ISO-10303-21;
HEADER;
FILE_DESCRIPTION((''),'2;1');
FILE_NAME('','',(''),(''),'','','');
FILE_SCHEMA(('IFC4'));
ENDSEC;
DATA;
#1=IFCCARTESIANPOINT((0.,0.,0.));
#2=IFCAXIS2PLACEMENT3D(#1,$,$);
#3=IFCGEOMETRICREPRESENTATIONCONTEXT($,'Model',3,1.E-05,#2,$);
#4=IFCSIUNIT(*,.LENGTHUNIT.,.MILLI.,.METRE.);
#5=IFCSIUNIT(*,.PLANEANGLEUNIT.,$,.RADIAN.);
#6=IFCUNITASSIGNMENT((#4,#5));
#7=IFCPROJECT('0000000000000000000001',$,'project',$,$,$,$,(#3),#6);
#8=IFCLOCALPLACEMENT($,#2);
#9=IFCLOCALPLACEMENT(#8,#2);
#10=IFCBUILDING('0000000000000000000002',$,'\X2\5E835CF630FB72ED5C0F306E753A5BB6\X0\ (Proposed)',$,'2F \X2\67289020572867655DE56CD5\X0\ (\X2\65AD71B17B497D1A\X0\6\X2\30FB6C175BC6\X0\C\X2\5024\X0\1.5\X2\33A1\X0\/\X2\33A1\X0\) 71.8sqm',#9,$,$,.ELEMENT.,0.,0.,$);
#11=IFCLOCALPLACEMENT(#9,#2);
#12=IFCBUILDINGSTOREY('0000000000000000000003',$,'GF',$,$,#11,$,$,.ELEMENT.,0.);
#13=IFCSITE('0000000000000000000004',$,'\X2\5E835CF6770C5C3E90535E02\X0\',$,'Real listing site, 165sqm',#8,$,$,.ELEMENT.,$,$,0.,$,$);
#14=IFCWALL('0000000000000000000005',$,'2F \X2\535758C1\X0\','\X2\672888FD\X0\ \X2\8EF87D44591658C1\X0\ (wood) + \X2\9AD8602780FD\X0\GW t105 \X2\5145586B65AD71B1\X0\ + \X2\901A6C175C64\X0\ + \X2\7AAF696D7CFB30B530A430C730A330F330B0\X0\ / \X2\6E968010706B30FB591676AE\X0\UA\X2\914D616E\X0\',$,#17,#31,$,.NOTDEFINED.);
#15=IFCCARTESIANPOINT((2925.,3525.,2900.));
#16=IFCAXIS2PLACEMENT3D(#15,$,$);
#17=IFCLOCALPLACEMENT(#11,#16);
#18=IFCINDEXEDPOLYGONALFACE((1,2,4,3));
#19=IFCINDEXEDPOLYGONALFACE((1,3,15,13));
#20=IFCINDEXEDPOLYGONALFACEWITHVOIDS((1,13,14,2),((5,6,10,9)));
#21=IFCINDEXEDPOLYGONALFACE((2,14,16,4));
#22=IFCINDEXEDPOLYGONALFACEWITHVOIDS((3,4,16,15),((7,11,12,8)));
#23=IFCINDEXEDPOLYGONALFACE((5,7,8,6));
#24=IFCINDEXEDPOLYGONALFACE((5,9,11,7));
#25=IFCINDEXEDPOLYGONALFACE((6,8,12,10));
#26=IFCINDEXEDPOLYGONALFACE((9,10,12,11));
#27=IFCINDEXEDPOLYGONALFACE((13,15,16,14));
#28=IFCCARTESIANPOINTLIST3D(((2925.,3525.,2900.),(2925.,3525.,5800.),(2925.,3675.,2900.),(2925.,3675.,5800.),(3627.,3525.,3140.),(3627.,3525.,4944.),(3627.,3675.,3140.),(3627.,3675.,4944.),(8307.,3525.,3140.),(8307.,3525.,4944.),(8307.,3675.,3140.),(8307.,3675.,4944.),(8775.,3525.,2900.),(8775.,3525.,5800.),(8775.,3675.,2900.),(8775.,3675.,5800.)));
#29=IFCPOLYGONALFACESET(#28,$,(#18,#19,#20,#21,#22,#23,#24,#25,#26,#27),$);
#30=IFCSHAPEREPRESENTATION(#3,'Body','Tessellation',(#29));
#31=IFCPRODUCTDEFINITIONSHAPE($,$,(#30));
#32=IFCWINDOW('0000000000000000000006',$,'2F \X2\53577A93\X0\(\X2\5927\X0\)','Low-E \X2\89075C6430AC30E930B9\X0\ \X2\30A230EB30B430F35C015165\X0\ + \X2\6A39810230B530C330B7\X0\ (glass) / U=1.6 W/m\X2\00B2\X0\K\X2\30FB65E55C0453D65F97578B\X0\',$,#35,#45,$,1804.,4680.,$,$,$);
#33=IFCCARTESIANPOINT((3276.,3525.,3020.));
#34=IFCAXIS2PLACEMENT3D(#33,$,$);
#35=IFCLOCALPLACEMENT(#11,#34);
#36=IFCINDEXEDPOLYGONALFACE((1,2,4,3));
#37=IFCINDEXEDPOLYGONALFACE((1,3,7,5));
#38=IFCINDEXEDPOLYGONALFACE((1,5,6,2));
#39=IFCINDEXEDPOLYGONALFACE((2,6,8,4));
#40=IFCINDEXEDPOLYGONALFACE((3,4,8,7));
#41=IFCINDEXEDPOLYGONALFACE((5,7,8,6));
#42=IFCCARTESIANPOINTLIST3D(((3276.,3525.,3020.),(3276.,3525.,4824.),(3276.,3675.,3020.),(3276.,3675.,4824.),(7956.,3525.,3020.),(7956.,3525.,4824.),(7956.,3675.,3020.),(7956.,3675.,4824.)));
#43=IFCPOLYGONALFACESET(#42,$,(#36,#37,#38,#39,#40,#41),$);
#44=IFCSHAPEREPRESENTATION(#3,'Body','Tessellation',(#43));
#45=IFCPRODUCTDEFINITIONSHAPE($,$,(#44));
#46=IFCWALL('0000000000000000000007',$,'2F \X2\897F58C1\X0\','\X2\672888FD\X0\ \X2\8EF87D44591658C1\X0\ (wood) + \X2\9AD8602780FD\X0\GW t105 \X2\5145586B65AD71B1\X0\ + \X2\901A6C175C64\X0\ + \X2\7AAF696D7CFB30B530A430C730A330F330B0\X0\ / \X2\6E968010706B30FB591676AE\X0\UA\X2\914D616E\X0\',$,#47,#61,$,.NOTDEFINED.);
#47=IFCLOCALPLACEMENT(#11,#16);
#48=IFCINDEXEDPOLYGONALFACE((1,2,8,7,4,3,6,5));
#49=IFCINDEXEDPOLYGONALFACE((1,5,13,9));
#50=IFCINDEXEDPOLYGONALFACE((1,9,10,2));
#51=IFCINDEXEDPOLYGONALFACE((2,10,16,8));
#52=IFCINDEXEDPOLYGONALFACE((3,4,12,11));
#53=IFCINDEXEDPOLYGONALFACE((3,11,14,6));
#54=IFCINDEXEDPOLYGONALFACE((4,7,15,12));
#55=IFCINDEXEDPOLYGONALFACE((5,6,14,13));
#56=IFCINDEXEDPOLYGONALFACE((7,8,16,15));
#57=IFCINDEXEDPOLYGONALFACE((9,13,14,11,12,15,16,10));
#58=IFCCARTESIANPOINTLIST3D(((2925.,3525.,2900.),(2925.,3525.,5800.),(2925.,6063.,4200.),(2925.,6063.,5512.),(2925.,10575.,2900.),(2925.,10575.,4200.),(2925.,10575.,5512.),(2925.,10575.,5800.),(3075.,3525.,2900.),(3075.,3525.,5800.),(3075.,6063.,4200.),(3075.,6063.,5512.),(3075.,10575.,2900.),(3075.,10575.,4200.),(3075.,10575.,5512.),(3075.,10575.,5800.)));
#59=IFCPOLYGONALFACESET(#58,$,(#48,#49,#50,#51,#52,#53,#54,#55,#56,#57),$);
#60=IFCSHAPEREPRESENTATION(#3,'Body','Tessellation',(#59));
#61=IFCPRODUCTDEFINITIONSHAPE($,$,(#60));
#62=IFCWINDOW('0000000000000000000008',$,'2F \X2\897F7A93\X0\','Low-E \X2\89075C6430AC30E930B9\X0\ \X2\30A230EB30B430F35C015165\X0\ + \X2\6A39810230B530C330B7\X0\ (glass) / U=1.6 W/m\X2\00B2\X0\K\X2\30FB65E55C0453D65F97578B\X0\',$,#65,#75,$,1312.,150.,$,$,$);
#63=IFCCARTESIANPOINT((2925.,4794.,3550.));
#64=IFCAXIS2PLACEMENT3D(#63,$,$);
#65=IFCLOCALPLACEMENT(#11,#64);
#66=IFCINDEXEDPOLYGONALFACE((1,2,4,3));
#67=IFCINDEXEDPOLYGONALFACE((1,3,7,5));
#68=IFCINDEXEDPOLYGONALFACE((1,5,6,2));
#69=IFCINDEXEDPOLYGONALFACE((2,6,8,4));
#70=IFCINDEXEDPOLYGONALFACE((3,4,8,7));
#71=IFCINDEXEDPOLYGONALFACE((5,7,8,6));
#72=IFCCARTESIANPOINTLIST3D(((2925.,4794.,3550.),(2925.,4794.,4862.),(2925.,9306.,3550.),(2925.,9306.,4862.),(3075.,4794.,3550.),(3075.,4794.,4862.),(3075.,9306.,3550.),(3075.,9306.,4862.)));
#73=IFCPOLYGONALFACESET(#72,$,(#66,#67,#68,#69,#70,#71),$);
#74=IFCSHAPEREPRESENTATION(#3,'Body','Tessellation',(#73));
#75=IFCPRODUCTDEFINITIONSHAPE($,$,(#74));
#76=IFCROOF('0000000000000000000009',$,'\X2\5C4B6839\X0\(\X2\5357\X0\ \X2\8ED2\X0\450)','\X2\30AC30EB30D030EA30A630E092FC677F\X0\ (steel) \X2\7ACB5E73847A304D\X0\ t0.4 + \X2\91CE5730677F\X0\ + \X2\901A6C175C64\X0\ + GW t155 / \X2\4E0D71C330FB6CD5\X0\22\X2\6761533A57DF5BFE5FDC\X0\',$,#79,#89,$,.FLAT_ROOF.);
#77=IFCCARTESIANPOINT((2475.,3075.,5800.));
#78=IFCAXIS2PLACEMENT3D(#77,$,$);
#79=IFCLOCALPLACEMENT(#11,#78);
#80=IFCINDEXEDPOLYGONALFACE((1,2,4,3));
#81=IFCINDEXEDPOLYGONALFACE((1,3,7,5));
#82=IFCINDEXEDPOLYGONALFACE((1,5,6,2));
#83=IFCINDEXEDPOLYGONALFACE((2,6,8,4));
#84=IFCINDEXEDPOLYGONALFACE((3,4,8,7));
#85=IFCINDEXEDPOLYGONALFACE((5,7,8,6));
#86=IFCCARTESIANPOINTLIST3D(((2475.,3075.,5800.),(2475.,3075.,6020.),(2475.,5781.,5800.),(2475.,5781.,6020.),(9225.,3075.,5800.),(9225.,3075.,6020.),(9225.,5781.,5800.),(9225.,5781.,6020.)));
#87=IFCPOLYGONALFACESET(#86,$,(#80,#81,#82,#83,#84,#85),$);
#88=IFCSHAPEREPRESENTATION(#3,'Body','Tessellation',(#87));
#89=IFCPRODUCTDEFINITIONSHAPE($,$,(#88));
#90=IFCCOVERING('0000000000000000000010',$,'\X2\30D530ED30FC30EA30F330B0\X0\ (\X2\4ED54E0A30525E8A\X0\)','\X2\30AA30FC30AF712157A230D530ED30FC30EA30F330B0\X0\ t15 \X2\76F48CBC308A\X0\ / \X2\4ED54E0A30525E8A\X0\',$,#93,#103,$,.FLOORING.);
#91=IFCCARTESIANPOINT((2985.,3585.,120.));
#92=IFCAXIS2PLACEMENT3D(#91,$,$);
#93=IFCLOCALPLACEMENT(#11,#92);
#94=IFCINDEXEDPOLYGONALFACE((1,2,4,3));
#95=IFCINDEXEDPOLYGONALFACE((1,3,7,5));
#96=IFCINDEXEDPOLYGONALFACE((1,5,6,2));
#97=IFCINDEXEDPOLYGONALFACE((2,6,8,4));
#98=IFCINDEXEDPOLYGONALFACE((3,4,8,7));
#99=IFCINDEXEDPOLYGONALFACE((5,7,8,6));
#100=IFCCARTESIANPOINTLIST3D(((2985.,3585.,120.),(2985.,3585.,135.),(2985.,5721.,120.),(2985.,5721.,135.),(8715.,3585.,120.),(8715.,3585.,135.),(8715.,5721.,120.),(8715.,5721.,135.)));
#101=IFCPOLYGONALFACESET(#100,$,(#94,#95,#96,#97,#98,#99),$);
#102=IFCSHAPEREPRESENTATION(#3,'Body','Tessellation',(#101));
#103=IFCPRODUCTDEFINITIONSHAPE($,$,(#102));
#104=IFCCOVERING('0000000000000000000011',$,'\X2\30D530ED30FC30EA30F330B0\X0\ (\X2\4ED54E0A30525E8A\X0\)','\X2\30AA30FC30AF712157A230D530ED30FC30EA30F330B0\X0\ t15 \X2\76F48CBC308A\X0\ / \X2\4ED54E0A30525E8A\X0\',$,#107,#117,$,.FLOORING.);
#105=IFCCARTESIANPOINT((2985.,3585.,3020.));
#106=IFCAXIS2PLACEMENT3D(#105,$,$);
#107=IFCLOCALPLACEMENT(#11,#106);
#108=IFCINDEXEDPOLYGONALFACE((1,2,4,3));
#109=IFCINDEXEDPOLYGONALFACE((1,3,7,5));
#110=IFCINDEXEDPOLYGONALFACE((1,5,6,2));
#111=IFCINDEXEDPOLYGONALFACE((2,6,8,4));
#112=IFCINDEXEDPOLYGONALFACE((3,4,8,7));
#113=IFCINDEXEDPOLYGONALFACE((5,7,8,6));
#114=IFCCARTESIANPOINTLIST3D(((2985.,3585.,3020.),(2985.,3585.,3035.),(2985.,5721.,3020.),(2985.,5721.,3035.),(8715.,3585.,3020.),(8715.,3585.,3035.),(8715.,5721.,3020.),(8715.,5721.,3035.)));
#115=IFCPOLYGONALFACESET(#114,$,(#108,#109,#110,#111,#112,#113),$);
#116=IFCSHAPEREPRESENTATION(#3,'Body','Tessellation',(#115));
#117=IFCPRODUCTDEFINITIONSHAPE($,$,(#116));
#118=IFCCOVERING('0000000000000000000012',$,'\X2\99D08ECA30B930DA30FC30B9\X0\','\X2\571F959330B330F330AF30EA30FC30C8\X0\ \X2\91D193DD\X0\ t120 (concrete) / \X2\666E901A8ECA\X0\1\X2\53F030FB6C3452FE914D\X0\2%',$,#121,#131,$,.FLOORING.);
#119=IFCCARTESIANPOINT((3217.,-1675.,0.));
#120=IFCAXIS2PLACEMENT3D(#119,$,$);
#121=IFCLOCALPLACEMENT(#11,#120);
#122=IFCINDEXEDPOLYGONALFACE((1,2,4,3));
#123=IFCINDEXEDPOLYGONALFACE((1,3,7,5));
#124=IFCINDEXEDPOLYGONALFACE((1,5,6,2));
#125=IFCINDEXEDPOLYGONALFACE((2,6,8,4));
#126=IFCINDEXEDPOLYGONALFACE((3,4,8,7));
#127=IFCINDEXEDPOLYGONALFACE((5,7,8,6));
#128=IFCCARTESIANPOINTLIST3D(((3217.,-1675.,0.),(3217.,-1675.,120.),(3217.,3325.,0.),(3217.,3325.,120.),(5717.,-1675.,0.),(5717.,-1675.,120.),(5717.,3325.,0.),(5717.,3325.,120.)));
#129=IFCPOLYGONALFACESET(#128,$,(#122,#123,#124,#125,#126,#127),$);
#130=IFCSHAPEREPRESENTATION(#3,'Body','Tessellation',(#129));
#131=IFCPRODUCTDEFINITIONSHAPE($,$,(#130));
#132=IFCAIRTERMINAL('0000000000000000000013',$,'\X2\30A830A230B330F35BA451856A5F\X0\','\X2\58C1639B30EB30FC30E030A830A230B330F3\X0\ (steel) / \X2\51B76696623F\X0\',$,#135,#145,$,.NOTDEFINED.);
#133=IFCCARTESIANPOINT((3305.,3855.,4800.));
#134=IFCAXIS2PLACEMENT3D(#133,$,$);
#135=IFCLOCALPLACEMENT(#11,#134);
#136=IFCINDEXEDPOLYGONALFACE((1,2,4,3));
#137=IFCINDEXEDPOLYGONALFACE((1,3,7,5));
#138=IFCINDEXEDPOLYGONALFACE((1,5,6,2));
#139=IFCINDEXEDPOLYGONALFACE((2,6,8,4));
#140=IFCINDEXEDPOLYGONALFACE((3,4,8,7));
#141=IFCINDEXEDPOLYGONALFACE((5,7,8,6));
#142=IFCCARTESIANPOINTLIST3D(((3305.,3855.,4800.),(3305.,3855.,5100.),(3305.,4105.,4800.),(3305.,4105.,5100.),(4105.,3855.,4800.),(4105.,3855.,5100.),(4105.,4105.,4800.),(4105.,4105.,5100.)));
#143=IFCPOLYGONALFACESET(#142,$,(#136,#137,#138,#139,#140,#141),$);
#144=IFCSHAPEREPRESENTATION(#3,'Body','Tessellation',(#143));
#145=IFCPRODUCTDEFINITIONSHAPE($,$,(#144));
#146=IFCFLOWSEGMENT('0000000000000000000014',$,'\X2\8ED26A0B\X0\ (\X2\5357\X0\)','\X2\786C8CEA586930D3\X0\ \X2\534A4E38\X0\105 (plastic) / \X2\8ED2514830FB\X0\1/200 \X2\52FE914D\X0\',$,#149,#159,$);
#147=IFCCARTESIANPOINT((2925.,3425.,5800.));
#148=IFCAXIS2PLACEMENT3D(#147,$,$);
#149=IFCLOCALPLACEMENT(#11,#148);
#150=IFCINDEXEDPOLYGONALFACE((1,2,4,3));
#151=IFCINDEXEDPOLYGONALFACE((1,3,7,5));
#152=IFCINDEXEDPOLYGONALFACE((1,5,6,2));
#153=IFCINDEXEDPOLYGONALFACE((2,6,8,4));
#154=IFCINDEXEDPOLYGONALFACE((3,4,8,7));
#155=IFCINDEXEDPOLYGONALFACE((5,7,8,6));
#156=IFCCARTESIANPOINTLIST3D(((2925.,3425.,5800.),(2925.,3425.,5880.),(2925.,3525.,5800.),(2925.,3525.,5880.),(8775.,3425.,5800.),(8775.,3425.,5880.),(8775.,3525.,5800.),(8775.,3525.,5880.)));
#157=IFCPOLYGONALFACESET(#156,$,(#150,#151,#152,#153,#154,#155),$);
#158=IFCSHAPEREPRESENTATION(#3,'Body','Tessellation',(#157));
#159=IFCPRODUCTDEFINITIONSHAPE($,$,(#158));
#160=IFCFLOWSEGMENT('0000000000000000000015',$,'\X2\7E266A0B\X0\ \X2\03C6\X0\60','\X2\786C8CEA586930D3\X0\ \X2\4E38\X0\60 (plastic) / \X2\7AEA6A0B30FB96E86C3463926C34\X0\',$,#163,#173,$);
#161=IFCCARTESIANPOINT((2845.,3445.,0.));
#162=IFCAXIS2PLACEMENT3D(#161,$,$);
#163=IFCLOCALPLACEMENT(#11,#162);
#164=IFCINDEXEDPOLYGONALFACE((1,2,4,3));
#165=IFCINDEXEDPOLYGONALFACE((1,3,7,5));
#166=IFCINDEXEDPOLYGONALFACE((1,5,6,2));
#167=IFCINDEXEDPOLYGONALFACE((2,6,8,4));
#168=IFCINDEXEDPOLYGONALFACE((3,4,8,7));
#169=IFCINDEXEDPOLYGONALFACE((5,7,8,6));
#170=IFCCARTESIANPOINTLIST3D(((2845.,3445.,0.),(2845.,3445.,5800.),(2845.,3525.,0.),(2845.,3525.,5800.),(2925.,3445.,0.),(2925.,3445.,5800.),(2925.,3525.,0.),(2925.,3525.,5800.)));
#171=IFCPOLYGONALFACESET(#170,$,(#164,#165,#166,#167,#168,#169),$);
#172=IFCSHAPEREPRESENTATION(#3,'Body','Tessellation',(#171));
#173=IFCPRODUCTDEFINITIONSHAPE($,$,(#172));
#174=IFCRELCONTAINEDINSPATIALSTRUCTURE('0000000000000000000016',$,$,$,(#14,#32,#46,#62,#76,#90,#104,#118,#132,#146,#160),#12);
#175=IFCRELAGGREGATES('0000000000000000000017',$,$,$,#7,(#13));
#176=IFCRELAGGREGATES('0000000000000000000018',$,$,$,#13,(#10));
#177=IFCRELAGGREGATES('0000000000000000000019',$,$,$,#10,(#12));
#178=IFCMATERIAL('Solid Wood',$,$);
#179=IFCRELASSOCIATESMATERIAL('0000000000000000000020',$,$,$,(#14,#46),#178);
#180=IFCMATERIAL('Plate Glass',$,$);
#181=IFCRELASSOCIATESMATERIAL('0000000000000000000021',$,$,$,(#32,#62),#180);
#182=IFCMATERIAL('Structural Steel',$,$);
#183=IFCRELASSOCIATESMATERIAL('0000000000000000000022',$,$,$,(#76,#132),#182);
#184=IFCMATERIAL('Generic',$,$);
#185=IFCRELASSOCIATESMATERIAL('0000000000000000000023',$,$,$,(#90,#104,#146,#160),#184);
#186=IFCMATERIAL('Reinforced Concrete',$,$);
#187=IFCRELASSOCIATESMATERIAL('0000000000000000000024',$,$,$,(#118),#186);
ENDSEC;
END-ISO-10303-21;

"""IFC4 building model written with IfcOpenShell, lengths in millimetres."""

from ifc_helpers import new_model, si_unit, frame, frame_2d, origin, place, context, project, spatial, rectangle, extrude, material, element, fill, save


model = new_model("IFC4")

# Units and contexts
model_context = context("Model", 3, precision=1e-05, world=origin())
ifc_project = project(units=[si_unit("LENGTHUNIT", "METRE", prefix="MILLI"), si_unit("PLANEANGLEUNIT", "RADIAN")], contexts=[model_context])

# Site, building, storey
site_placement = place(None, origin())
site = spatial("IfcSite", under=ifc_project, at=site_placement, Name="広島県尾道市", ObjectType="Real listing site, 165sqm", CompositionType="ELEMENT", RefElevation=0.0)
building_placement = place(site_placement, origin())
building = spatial("IfcBuilding", under=site, at=building_placement, Name="広島・狭小の町家 (Proposed)", ObjectType="2F 木造在来工法 (断熱等級6・気密C値1.5㎡/㎡) 71.8sqm", CompositionType="ELEMENT", ElevationOfRefHeight=0.0, ElevationOfTerrain=0.0)
storey_placement = place(building_placement, origin())
storey = spatial("IfcBuildingStorey", under=building, at=storey_placement, Name="GF", CompositionType="ELEMENT", Elevation=0.0)

# Shared definitions
ifc_material_1 = material(Name="Solid Wood")

# Shared definitions
ifc_material_2 = material(Name="Reinforced Concrete")

# Shared definitions
ifc_material_3 = material(Name="Plate Glass")

# Walls, openings, windows
wall_1_placement = place(storey_placement, frame((2925.0, 3525.0, 2900.0)))
wall_1 = element("IfcWall", 1, at=wall_1_placement, inside=storey, material=ifc_material_1, Name="2F 南壁", Description="木製 軸組外壁 (wood) + 高性能GW t105 充填断熱 + 通気層 + 窯業系サイディング / 準耐火・外皮UA配慮", PredefinedType="NOTDEFINED", context=model_context, shape_type="SweptSolid", body=[
    extrude(rectangle(XDim=5850.0, YDim=150.0, at=frame_2d((2925.0, 75.0))), frame((2925.0, 3525.0, 2900.0)), (0.0, 0.0, 1.0), 2900.0),
])
opening_1_placement = place(storey_placement, frame((3276.0, 3525.0, 3020.0)))
opening_1 = element("IfcOpeningElement", 2, at=opening_1_placement, cuts=wall_1, PredefinedType="NOTDEFINED", context=model_context, shape_type="SweptSolid", body=[
    extrude(rectangle(XDim=4680.0, YDim=150.0, at=frame_2d((2340.0, 75.0))), frame((3276.0, 3525.0, 3020.0)), (0.0, 0.0, 1.0), 1804.0),
])
window_1_placement = place(storey_placement, frame((3276.0, 3525.0, 3020.0)))
window_1 = element("IfcWindow", 3, at=window_1_placement, inside=storey, material=ifc_material_3, Name="2F 南窓(大)", Description="Low-E 複層ガラス アルゴン封入 + 樹脂サッシ (glass) / U=1.6 W/m²K・日射取得型", OverallHeight=1804.0, OverallWidth=4680.0, context=model_context, shape_type="SweptSolid", body=[
    extrude(rectangle(XDim=4680.0, YDim=150.0, at=frame_2d((2340.0, 75.0))), frame((3276.0, 3525.0, 3020.0)), (0.0, 0.0, 1.0), 1804.0),
])
fill(opening_1, window_1)
wall_2_placement = place(storey_placement, frame((2925.0, 3525.0, 2900.0)))
wall_2 = element("IfcWall", 4, at=wall_2_placement, inside=storey, material=ifc_material_1, Name="2F 西壁", Description="木製 軸組外壁 (wood) + 高性能GW t105 充填断熱 + 通気層 + 窯業系サイディング / 準耐火・外皮UA配慮", PredefinedType="NOTDEFINED", context=model_context, shape_type="SweptSolid", body=[
    extrude(rectangle(XDim=150.0, YDim=7050.0, at=frame_2d((75.0, 3525.0))), frame((2925.0, 3525.0, 2900.0)), (0.0, 0.0, 1.0), 2900.0),
])
opening_2_placement = place(storey_placement, frame((2925.0, 4794.0, 3550.0)))
opening_2 = element("IfcOpeningElement", 5, at=opening_2_placement, cuts=wall_2, PredefinedType="NOTDEFINED", context=model_context, shape_type="SweptSolid", body=[
    extrude(rectangle(XDim=150.0, YDim=4512.0, at=frame_2d((75.0, 2256.0))), frame((2925.0, 4794.0, 3550.0)), (0.0, 0.0, 1.0), 1312.0),
])
window_2_placement = place(storey_placement, frame((2925.0, 4794.0, 3550.0)))
window_2 = element("IfcWindow", 6, at=window_2_placement, inside=storey, material=ifc_material_3, Name="2F 西窓", Description="Low-E 複層ガラス アルゴン封入 + 樹脂サッシ (glass) / U=1.6 W/m²K・日射取得型", OverallHeight=1312.0, OverallWidth=150.0, context=model_context, shape_type="SweptSolid", body=[
    extrude(rectangle(XDim=150.0, YDim=4512.0, at=frame_2d((75.0, 2256.0))), frame((2925.0, 4794.0, 3550.0)), (0.0, 0.0, 1.0), 1312.0),
])
fill(opening_2, window_2)

# Roof
ifc_material_4 = material(Name="Structural Steel")
for number, where, name in (
    (7, (2475.0, 3075.0, 5800.0), "屋根(南 軒450)"),
):
    element("IfcRoof", number, at=place(storey_placement, frame(where)), inside=storey, material=ifc_material_4, Name=name, Description="ガルバリウム鋼板 (steel) 立平葺き t0.4 + 野地板 + 通気層 + GW t155 / 不燃・法22条区域対応", PredefinedType="FLAT_ROOF", context=model_context, shape_type="SweptSolid", body=[
        extrude(rectangle(XDim=6750.0, YDim=2706.0, at=frame_2d((3375.0, 1353.0))), frame((2475.0, 3075.0, 5800.0)), (0.0, 0.0, 1.0), 220.0),
    ])

# Coverings
ifc_material_5 = material(Name="Generic")
covering_1_placement = place(storey_placement, frame((2985.0, 3585.0, 120.0)))
element("IfcCovering", 8, at=covering_1_placement, inside=storey, material=ifc_material_5, Name="フローリング (仕上げ床)", Description="オーク無垢フローリング t15 直貼り / 仕上げ床", PredefinedType="FLOORING", context=model_context, shape_type="SweptSolid", body=[
    extrude(rectangle(XDim=5730.0, YDim=2136.0, at=frame_2d((2865.0, 1068.0))), frame((2985.0, 3585.0, 120.0)), (0.0, 0.0, 1.0), 15.0),
])
covering_2_placement = place(storey_placement, frame((2985.0, 3585.0, 3020.0)))
element("IfcCovering", 9, at=covering_2_placement, inside=storey, material=ifc_material_5, Name="フローリング (仕上げ床)", Description="オーク無垢フローリング t15 直貼り / 仕上げ床", PredefinedType="FLOORING", context=model_context, shape_type="SweptSolid", body=[
    extrude(rectangle(XDim=5730.0, YDim=2136.0, at=frame_2d((2865.0, 1068.0))), frame((2985.0, 3585.0, 3020.0)), (0.0, 0.0, 1.0), 15.0),
])
covering_3_placement = place(storey_placement, frame((3217.0, -1675.0, 0.0)))
element("IfcCovering", 10, at=covering_3_placement, inside=storey, material=ifc_material_2, Name="駐車スペース", Description="土間コンクリート 金鏝 t120 (concrete) / 普通車1台・水勾配2%", PredefinedType="FLOORING", context=model_context, shape_type="SweptSolid", body=[
    extrude(rectangle(XDim=2500.0, YDim=5000.0, at=frame_2d((1250.0, 2500.0))), frame((3217.0, -1675.0, 0.0)), (0.0, 0.0, 1.0), 120.0),
])

# Air terminal
air_terminal_placement = place(storey_placement, frame((3305.0, 3855.0, 4800.0)))
element("IfcAirTerminal", 11, at=air_terminal_placement, inside=storey, material=ifc_material_4, Name="エアコン室内機", Description="壁掛ルームエアコン (steel) / 冷暖房", PredefinedType="NOTDEFINED", context=model_context, shape_type="SweptSolid", body=[
    extrude(rectangle(XDim=800.0, YDim=250.0, at=frame_2d((400.0, 125.0))), frame((3305.0, 3855.0, 4800.0)), (0.0, 0.0, 1.0), 300.0),
])

# Flow segments
flow_segment_1_placement = place(storey_placement, frame((2925.0, 3425.0, 5800.0)))
element("IfcFlowSegment", 12, at=flow_segment_1_placement, inside=storey, material=ifc_material_5, Name="軒樋 (南)", Description="硬質塩ビ 半丸105 (plastic) / 軒先・1/200 勾配", context=model_context, shape_type="SweptSolid", body=[
    extrude(rectangle(XDim=5850.0, YDim=100.0, at=frame_2d((2925.0, 50.0))), frame((2925.0, 3425.0, 5800.0)), (0.0, 0.0, 1.0), 80.0),
])
flow_segment_2_placement = place(storey_placement, frame((2845.0, 3445.0, 0.0)))
element("IfcFlowSegment", 13, at=flow_segment_2_placement, inside=storey, material=ifc_material_5, Name="縦樋 φ60", Description="硬質塩ビ 丸60 (plastic) / 竪樋・雨水排水", context=model_context, shape_type="SweptSolid", body=[
    extrude(rectangle(XDim=80.0, YDim=80.0, at=frame_2d((40.0, 40.0))), frame((2845.0, 3445.0, 0.0)), (0.0, 0.0, 1.0), 5800.0),
])

save(model, "model.ifc")
